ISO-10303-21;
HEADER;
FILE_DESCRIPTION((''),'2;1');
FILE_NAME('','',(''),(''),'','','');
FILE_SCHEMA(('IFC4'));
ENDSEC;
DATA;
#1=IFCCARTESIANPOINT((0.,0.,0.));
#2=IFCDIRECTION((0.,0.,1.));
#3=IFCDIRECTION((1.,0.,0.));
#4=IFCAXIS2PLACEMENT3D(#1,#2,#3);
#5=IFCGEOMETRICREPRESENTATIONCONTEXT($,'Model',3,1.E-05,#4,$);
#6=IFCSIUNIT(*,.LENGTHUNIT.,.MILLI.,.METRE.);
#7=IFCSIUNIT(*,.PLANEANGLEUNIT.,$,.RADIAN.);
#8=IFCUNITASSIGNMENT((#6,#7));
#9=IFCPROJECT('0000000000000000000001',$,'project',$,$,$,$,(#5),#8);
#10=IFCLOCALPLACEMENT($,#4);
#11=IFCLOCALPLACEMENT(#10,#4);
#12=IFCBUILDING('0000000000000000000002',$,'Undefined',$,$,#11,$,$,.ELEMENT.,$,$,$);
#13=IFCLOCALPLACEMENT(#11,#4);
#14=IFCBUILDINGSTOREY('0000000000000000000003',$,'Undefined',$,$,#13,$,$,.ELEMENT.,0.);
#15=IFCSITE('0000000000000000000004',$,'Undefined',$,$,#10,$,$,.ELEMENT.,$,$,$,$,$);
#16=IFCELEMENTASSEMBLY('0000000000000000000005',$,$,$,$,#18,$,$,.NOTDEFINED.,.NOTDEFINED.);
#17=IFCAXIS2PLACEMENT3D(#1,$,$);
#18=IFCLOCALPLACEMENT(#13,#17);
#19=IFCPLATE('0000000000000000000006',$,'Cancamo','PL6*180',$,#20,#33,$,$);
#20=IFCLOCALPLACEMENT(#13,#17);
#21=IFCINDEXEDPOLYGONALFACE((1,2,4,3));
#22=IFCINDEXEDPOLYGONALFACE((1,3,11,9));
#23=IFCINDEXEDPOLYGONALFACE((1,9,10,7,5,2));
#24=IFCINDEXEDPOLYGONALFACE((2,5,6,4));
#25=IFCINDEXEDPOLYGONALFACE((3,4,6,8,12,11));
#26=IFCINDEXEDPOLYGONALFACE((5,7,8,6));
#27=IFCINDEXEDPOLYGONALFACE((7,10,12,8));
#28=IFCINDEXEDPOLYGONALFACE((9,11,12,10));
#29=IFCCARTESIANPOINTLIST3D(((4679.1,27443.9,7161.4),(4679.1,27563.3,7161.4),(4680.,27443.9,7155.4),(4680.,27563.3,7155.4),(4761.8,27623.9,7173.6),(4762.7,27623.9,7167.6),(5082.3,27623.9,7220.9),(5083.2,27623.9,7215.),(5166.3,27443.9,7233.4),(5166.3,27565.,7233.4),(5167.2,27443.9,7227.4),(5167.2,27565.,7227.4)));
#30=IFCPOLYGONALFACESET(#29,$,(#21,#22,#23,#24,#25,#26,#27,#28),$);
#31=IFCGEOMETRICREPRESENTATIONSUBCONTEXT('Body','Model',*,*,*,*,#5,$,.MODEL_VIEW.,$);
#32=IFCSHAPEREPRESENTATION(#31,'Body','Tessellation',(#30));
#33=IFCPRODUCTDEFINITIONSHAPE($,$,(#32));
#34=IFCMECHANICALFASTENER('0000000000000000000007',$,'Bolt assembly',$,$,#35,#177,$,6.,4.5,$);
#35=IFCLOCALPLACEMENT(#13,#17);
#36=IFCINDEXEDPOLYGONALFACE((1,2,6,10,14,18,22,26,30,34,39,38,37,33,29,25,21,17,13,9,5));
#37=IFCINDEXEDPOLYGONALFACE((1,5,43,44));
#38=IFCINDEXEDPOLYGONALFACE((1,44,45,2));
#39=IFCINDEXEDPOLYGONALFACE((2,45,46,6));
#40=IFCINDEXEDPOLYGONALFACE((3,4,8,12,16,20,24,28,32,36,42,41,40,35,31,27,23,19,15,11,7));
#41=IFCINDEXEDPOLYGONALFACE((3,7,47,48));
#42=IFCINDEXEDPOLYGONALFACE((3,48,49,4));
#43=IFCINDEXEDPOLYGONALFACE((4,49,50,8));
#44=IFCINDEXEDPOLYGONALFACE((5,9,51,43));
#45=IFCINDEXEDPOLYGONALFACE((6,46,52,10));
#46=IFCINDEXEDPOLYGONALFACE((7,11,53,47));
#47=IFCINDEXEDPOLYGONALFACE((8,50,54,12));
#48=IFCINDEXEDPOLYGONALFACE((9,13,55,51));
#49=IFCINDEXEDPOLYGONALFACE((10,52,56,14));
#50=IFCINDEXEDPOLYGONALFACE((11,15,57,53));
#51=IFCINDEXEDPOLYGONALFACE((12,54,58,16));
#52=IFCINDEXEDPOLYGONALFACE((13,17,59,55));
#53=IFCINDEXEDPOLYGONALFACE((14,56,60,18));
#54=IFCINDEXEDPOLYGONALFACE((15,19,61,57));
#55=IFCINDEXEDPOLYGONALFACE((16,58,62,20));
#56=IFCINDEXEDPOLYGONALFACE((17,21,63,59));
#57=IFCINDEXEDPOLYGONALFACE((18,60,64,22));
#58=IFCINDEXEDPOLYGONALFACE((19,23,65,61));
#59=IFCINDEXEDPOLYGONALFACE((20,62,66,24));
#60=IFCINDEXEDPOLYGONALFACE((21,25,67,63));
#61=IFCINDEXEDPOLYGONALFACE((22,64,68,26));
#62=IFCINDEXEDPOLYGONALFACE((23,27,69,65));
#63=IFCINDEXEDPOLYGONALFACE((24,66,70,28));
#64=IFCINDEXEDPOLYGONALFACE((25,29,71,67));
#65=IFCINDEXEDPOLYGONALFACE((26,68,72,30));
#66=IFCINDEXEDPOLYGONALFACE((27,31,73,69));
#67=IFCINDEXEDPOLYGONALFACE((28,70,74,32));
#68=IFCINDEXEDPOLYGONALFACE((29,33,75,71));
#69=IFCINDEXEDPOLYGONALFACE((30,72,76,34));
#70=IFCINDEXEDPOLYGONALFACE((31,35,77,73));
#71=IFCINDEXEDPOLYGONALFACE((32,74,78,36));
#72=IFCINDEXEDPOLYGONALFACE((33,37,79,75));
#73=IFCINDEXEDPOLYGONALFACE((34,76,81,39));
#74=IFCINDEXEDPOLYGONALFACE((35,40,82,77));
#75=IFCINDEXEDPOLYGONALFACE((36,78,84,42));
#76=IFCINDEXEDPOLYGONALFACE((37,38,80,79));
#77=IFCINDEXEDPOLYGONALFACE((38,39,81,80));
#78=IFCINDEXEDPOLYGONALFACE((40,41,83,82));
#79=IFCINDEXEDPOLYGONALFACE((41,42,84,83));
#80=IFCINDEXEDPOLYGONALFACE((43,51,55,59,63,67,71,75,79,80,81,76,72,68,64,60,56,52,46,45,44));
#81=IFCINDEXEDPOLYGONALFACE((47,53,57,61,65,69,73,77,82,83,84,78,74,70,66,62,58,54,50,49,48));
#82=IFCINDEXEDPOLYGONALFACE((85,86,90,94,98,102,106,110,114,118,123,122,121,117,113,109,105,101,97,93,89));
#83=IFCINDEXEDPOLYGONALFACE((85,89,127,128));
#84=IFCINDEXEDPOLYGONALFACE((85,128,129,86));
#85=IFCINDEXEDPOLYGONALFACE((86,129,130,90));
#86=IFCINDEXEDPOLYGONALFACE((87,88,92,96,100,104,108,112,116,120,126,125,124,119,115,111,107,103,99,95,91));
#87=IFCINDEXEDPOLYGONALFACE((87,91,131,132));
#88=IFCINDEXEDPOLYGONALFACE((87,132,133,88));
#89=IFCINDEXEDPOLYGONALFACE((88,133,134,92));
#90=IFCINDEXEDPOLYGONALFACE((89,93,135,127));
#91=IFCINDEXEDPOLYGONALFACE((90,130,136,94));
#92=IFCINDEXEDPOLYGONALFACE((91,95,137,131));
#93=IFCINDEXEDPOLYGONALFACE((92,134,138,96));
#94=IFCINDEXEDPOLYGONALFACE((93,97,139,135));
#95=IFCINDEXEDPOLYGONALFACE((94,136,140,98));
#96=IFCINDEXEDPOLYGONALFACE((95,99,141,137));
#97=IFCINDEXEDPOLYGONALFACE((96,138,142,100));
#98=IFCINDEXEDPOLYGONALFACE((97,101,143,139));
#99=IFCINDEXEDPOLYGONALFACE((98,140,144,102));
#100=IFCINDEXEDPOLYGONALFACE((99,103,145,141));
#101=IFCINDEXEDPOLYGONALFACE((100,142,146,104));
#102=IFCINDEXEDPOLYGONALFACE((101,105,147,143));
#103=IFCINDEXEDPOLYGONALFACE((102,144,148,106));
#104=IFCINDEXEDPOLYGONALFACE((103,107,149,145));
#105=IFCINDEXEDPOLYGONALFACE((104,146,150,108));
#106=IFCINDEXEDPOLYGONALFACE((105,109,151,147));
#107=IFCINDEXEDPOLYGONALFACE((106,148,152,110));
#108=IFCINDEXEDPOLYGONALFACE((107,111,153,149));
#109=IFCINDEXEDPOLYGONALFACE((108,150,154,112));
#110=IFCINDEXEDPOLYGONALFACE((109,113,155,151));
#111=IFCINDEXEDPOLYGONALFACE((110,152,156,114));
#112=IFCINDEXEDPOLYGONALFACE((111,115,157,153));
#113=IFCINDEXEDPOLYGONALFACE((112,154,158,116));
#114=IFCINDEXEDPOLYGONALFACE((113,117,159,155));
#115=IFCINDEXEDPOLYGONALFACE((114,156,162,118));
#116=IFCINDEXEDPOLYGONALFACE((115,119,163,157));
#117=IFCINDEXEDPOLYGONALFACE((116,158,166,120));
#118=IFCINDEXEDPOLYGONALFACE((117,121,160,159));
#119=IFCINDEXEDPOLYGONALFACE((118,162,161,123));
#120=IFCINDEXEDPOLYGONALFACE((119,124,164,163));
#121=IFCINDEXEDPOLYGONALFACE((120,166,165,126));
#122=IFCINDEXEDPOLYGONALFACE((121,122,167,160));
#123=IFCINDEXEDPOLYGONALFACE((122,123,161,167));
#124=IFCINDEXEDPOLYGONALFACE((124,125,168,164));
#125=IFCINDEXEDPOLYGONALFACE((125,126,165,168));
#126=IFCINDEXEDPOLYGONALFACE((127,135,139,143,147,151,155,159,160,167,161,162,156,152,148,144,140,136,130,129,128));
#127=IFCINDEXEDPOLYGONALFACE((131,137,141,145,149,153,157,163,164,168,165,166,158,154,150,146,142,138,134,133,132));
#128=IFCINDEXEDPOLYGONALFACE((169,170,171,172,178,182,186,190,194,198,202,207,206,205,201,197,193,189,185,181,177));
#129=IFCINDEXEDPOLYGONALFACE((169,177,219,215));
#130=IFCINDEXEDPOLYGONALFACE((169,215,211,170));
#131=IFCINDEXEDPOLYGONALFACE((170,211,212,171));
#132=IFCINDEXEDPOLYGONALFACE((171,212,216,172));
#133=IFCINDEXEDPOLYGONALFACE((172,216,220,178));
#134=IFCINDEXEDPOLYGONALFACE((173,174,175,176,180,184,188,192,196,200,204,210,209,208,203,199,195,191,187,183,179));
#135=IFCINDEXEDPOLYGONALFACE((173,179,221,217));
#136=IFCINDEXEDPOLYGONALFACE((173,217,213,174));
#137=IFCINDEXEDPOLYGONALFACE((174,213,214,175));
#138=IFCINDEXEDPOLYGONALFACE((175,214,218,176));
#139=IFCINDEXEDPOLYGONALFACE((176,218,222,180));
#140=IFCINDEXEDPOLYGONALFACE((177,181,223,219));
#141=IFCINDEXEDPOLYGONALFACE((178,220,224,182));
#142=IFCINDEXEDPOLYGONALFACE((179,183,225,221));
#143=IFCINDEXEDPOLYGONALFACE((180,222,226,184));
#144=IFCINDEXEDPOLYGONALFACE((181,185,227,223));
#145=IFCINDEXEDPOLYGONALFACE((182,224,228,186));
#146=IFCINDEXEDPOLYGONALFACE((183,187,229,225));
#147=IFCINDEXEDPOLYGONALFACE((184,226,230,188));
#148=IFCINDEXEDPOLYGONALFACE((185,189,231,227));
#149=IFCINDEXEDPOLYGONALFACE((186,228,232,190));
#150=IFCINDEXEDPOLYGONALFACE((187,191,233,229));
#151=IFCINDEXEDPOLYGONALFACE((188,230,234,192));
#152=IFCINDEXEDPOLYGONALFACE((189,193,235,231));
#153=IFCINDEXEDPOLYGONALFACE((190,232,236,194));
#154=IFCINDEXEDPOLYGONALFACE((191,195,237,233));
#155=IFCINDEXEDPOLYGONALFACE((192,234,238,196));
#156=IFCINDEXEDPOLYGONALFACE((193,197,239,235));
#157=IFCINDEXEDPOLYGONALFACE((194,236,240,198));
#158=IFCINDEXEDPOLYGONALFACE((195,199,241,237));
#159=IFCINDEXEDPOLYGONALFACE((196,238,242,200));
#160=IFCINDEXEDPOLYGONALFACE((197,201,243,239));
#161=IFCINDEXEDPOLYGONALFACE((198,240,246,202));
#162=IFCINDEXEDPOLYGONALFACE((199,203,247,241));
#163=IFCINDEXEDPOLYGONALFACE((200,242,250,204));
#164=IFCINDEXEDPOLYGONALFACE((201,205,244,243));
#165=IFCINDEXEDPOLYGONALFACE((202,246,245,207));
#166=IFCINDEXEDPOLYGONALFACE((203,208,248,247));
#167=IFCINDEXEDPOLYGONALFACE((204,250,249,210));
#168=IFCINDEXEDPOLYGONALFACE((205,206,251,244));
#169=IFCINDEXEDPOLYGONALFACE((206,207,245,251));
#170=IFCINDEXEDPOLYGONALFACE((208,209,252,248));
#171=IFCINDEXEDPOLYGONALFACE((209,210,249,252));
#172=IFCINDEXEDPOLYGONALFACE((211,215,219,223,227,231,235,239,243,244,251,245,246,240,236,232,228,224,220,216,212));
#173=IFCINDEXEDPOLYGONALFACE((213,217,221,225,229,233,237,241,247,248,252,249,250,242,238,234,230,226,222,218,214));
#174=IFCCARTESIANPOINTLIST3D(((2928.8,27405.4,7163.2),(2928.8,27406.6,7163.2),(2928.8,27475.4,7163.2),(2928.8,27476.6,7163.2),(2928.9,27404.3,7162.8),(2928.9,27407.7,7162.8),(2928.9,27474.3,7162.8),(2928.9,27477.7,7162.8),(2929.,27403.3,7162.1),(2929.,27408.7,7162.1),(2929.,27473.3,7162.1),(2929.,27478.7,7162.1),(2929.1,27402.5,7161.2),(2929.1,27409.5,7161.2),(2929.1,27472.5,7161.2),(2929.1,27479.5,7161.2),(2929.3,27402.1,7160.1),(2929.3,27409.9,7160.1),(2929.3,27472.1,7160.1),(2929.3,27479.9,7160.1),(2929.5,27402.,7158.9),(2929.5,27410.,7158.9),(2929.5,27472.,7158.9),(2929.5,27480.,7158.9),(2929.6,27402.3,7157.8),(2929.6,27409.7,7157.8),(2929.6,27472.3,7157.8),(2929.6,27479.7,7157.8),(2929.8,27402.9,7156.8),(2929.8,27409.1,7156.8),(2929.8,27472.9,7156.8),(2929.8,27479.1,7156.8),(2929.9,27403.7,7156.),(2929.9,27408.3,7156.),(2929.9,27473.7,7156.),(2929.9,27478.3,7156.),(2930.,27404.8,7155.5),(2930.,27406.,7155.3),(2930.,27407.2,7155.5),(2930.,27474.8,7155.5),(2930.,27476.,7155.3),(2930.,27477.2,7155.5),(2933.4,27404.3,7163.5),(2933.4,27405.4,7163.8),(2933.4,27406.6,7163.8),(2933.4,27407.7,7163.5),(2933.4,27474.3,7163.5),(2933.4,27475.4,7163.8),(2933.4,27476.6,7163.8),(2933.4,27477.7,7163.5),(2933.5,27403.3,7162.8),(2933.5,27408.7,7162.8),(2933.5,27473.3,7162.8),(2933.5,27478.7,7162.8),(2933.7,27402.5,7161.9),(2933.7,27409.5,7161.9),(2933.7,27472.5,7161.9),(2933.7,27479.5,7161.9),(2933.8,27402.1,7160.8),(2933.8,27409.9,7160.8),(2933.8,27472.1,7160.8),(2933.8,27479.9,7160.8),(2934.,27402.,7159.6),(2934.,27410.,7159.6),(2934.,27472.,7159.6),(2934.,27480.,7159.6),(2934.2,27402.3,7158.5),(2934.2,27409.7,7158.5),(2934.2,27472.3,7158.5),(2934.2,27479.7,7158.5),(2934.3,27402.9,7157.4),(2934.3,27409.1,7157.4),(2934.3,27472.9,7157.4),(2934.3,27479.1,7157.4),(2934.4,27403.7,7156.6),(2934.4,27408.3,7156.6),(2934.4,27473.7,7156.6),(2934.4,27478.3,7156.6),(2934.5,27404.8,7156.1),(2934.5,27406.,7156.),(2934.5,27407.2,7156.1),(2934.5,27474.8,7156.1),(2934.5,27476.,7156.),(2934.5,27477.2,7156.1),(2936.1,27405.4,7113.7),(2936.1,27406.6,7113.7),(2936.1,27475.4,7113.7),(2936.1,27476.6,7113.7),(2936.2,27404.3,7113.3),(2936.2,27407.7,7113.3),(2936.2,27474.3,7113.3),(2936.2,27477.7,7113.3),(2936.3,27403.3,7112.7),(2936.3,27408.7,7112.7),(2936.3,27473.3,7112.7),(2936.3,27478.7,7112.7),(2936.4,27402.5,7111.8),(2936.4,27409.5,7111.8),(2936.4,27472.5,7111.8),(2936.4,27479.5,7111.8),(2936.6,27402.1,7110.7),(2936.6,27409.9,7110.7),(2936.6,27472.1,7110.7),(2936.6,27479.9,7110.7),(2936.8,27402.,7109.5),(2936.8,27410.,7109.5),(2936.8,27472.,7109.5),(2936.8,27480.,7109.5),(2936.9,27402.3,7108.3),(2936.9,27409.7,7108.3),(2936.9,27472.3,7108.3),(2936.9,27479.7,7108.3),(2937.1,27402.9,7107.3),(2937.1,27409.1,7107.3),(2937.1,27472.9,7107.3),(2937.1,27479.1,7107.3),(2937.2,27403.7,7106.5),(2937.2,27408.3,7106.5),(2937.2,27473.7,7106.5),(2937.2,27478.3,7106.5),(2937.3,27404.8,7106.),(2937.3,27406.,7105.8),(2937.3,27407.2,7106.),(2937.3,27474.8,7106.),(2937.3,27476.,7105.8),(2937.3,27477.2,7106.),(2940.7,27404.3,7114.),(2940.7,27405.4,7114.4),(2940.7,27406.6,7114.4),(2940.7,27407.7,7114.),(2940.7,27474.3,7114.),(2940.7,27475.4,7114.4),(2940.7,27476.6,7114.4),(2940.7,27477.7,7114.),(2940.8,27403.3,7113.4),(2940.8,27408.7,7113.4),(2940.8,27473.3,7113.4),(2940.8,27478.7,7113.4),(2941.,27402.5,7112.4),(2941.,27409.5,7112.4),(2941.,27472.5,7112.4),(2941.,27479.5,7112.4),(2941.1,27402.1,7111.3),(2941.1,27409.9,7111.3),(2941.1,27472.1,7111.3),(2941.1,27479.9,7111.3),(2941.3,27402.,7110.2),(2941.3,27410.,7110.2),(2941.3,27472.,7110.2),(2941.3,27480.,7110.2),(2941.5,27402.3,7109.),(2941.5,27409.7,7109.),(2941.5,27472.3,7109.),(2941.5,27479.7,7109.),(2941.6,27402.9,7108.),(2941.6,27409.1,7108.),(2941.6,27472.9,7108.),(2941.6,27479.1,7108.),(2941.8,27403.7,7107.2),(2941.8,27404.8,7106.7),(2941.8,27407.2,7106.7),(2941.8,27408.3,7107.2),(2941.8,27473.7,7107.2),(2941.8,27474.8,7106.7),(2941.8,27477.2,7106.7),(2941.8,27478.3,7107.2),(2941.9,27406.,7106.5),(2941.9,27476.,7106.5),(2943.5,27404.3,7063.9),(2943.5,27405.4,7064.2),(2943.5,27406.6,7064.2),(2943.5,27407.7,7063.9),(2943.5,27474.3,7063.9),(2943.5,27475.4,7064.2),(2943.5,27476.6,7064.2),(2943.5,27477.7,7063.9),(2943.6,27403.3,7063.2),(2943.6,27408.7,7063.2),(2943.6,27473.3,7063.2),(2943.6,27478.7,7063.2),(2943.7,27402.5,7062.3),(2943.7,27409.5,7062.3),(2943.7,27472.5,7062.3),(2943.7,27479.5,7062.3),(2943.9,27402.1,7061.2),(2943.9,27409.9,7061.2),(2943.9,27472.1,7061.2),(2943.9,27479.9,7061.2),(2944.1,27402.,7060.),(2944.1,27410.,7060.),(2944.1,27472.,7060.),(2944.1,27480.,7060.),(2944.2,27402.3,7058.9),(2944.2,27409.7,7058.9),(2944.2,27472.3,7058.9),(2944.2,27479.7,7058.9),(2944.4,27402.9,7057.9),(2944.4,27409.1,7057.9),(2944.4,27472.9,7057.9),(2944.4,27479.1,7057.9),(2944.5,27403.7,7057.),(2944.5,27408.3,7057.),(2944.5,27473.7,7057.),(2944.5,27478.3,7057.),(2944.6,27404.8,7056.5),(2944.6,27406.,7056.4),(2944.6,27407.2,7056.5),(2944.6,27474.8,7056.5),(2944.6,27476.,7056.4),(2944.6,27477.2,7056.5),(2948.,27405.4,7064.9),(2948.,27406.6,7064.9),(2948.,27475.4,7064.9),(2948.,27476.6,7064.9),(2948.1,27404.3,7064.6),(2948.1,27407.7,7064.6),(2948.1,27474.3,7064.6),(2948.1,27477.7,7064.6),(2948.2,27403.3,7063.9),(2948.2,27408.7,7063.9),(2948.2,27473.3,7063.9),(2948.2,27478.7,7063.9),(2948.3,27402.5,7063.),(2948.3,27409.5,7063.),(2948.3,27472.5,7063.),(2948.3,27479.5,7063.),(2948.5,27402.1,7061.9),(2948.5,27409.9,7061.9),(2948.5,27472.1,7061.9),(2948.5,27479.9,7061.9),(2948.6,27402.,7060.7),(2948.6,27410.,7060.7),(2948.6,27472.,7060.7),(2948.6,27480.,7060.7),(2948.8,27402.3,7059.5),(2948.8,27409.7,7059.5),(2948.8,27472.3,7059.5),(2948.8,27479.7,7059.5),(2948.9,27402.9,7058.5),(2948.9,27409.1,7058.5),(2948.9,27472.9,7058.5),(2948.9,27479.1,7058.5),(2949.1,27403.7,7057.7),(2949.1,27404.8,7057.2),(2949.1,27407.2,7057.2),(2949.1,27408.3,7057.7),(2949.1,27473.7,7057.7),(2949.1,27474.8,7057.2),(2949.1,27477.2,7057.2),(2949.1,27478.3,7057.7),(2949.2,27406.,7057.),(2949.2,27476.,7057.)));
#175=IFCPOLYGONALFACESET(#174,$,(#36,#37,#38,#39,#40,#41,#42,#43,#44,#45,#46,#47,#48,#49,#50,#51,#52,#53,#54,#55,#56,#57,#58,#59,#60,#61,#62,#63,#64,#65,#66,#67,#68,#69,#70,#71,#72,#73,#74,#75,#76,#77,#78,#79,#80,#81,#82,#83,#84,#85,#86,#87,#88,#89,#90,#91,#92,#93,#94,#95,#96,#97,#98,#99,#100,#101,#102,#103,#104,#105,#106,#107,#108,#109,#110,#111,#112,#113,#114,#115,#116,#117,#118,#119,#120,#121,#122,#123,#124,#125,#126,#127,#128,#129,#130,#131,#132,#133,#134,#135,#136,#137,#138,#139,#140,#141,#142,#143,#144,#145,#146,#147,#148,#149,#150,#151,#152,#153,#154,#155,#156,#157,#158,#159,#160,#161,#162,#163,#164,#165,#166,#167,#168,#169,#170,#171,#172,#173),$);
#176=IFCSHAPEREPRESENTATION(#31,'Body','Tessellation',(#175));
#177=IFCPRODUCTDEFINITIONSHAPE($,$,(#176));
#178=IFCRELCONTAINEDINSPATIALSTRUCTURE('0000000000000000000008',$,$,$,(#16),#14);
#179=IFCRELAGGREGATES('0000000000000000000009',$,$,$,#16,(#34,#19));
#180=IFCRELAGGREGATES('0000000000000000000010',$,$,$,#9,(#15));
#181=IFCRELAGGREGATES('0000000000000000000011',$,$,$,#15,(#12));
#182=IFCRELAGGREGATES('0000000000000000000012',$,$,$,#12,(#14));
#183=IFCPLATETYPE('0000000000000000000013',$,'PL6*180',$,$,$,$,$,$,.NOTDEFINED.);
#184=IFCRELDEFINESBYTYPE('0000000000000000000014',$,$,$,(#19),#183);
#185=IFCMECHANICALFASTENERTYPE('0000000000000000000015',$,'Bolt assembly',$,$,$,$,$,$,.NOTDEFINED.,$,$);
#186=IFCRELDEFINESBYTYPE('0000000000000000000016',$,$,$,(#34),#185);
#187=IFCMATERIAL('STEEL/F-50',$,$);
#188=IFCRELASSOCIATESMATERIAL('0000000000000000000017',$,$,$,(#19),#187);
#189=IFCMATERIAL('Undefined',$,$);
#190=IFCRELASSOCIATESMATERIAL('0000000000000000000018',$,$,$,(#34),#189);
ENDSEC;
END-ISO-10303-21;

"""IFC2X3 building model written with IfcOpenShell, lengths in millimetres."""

from ifc_helpers import new_model, si_unit, frame, origin_with_axes, origin_2d_with_axis, place, context, subcontext, project, spatial, polyline, circle, outline, extrude, source, transform, mapped, material, type_object, element, aggregate, save


model = new_model("IFC2X3")

# Units and contexts
model_context = context("Model", 3, precision=1e-05, world=origin_with_axes())
body_context = subcontext(model_context, "Body", "Model", "MODEL_VIEW")
ifc_project = project(units=[si_unit("LENGTHUNIT", "METRE", prefix="MILLI"), si_unit("PLANEANGLEUNIT", "RADIAN")], contexts=[model_context])

# Site, building, storey
site_placement = place(None, origin_with_axes())
site = spatial("IfcSite", under=ifc_project, at=site_placement, Name="Undefined", CompositionType="ELEMENT")
building_placement = place(site_placement, origin_with_axes())
building = spatial("IfcBuilding", under=site, at=building_placement, Name="Undefined", CompositionType="ELEMENT")
storey_placement = place(building_placement, origin_with_axes())
storey = spatial("IfcBuildingStorey", under=building, at=storey_placement, Name="Undefined", CompositionType="ELEMENT", Elevation=0.0)

# Element assembly
assembly_1_placement = place(storey_placement, origin_with_axes())
assembly_1 = element("IfcElementAssembly", 1, at=assembly_1_placement, inside=storey, AssemblyPlace="NOTDEFINED", PredefinedType="NOTDEFINED")

# Plate
ifc_material_1 = material(Name="STEEL/F-50")
plate_type_1 = type_object("IfcPlateType", Name="PL6*180", PredefinedType="NOTDEFINED")
plate_1_placement = place(assembly_1_placement, frame((4679.6, 27443.9, 7158.4), z_axis=(-0.146202, 0.0, 0.989255), x_axis=(0.989255, 0.0, 0.146202)))
plate_1 = element("IfcPlate", 2, at=plate_1_placement, type_object=plate_type_1, material=ifc_material_1, Name="Cancamo", Description="PL6*180", context=body_context, shape_type="SweptSolid", body=[
    extrude(outline(polyline([(0.0, 0.0), (492.4, 0.0), (492.4, 121.1), (407.6, 180.0), (83.6, 180.0), (0.0, 119.4), (0.0, 0.0)])), frame((0.0, 0.0, -3.0), z_axis=(0.0, 0.0, 1.0), x_axis=(1.0, 0.0, 0.0)), (0.0, 0.0, 1.0), 6.0),
])

# Mechanical fastener
ifc_material_2 = material(Name="Undefined")
mechanical_fastener_type = type_object("IfcMechanicalFastenerType", Name="Bolt assembly")
shared_shape_1 = source(origin_with_axes(), body_context, "Body", "SweptSolid", [
    extrude(circle(Radius=4.0, at=origin_2d_with_axis()), frame((0.0, 0.0, 0.0), z_axis=(0.0, 1.0, 0.0), x_axis=(1.0, 0.0, 0.0)), (0.0, 0.0, 1.0), 4.6),
])
mechanical_fastener_1_placement = place(assembly_1_placement, frame((2929.4, 27441.0, 7159.2), z_axis=(0.0, -1.0, 0.0), x_axis=(0.146203, 0.0, -0.989255)))
mechanical_fastener_1 = element("IfcMechanicalFastener", 3, at=mechanical_fastener_1_placement, type_object=mechanical_fastener_type, material=ifc_material_2, Name="Bolt assembly", NominalDiameter=6.0, NominalLength=4.5, context=body_context, shape_type="MappedRepresentation", body=[
    mapped(shared_shape_1, transform((0.0, 0.0, -35.0))),
    mapped(shared_shape_1, transform((50.0, 0.0, -35.0))),
    mapped(shared_shape_1, transform((100.0, 0.0, -35.0))),
    mapped(shared_shape_1, transform((0.0, 0.0, 35.0))),
    mapped(shared_shape_1, transform((50.0, 0.0, 35.0))),
    mapped(shared_shape_1, transform((100.0, 0.0, 35.0))),
])

aggregate(assembly_1, [mechanical_fastener_1, plate_1])

save(model, "model.ifc")
